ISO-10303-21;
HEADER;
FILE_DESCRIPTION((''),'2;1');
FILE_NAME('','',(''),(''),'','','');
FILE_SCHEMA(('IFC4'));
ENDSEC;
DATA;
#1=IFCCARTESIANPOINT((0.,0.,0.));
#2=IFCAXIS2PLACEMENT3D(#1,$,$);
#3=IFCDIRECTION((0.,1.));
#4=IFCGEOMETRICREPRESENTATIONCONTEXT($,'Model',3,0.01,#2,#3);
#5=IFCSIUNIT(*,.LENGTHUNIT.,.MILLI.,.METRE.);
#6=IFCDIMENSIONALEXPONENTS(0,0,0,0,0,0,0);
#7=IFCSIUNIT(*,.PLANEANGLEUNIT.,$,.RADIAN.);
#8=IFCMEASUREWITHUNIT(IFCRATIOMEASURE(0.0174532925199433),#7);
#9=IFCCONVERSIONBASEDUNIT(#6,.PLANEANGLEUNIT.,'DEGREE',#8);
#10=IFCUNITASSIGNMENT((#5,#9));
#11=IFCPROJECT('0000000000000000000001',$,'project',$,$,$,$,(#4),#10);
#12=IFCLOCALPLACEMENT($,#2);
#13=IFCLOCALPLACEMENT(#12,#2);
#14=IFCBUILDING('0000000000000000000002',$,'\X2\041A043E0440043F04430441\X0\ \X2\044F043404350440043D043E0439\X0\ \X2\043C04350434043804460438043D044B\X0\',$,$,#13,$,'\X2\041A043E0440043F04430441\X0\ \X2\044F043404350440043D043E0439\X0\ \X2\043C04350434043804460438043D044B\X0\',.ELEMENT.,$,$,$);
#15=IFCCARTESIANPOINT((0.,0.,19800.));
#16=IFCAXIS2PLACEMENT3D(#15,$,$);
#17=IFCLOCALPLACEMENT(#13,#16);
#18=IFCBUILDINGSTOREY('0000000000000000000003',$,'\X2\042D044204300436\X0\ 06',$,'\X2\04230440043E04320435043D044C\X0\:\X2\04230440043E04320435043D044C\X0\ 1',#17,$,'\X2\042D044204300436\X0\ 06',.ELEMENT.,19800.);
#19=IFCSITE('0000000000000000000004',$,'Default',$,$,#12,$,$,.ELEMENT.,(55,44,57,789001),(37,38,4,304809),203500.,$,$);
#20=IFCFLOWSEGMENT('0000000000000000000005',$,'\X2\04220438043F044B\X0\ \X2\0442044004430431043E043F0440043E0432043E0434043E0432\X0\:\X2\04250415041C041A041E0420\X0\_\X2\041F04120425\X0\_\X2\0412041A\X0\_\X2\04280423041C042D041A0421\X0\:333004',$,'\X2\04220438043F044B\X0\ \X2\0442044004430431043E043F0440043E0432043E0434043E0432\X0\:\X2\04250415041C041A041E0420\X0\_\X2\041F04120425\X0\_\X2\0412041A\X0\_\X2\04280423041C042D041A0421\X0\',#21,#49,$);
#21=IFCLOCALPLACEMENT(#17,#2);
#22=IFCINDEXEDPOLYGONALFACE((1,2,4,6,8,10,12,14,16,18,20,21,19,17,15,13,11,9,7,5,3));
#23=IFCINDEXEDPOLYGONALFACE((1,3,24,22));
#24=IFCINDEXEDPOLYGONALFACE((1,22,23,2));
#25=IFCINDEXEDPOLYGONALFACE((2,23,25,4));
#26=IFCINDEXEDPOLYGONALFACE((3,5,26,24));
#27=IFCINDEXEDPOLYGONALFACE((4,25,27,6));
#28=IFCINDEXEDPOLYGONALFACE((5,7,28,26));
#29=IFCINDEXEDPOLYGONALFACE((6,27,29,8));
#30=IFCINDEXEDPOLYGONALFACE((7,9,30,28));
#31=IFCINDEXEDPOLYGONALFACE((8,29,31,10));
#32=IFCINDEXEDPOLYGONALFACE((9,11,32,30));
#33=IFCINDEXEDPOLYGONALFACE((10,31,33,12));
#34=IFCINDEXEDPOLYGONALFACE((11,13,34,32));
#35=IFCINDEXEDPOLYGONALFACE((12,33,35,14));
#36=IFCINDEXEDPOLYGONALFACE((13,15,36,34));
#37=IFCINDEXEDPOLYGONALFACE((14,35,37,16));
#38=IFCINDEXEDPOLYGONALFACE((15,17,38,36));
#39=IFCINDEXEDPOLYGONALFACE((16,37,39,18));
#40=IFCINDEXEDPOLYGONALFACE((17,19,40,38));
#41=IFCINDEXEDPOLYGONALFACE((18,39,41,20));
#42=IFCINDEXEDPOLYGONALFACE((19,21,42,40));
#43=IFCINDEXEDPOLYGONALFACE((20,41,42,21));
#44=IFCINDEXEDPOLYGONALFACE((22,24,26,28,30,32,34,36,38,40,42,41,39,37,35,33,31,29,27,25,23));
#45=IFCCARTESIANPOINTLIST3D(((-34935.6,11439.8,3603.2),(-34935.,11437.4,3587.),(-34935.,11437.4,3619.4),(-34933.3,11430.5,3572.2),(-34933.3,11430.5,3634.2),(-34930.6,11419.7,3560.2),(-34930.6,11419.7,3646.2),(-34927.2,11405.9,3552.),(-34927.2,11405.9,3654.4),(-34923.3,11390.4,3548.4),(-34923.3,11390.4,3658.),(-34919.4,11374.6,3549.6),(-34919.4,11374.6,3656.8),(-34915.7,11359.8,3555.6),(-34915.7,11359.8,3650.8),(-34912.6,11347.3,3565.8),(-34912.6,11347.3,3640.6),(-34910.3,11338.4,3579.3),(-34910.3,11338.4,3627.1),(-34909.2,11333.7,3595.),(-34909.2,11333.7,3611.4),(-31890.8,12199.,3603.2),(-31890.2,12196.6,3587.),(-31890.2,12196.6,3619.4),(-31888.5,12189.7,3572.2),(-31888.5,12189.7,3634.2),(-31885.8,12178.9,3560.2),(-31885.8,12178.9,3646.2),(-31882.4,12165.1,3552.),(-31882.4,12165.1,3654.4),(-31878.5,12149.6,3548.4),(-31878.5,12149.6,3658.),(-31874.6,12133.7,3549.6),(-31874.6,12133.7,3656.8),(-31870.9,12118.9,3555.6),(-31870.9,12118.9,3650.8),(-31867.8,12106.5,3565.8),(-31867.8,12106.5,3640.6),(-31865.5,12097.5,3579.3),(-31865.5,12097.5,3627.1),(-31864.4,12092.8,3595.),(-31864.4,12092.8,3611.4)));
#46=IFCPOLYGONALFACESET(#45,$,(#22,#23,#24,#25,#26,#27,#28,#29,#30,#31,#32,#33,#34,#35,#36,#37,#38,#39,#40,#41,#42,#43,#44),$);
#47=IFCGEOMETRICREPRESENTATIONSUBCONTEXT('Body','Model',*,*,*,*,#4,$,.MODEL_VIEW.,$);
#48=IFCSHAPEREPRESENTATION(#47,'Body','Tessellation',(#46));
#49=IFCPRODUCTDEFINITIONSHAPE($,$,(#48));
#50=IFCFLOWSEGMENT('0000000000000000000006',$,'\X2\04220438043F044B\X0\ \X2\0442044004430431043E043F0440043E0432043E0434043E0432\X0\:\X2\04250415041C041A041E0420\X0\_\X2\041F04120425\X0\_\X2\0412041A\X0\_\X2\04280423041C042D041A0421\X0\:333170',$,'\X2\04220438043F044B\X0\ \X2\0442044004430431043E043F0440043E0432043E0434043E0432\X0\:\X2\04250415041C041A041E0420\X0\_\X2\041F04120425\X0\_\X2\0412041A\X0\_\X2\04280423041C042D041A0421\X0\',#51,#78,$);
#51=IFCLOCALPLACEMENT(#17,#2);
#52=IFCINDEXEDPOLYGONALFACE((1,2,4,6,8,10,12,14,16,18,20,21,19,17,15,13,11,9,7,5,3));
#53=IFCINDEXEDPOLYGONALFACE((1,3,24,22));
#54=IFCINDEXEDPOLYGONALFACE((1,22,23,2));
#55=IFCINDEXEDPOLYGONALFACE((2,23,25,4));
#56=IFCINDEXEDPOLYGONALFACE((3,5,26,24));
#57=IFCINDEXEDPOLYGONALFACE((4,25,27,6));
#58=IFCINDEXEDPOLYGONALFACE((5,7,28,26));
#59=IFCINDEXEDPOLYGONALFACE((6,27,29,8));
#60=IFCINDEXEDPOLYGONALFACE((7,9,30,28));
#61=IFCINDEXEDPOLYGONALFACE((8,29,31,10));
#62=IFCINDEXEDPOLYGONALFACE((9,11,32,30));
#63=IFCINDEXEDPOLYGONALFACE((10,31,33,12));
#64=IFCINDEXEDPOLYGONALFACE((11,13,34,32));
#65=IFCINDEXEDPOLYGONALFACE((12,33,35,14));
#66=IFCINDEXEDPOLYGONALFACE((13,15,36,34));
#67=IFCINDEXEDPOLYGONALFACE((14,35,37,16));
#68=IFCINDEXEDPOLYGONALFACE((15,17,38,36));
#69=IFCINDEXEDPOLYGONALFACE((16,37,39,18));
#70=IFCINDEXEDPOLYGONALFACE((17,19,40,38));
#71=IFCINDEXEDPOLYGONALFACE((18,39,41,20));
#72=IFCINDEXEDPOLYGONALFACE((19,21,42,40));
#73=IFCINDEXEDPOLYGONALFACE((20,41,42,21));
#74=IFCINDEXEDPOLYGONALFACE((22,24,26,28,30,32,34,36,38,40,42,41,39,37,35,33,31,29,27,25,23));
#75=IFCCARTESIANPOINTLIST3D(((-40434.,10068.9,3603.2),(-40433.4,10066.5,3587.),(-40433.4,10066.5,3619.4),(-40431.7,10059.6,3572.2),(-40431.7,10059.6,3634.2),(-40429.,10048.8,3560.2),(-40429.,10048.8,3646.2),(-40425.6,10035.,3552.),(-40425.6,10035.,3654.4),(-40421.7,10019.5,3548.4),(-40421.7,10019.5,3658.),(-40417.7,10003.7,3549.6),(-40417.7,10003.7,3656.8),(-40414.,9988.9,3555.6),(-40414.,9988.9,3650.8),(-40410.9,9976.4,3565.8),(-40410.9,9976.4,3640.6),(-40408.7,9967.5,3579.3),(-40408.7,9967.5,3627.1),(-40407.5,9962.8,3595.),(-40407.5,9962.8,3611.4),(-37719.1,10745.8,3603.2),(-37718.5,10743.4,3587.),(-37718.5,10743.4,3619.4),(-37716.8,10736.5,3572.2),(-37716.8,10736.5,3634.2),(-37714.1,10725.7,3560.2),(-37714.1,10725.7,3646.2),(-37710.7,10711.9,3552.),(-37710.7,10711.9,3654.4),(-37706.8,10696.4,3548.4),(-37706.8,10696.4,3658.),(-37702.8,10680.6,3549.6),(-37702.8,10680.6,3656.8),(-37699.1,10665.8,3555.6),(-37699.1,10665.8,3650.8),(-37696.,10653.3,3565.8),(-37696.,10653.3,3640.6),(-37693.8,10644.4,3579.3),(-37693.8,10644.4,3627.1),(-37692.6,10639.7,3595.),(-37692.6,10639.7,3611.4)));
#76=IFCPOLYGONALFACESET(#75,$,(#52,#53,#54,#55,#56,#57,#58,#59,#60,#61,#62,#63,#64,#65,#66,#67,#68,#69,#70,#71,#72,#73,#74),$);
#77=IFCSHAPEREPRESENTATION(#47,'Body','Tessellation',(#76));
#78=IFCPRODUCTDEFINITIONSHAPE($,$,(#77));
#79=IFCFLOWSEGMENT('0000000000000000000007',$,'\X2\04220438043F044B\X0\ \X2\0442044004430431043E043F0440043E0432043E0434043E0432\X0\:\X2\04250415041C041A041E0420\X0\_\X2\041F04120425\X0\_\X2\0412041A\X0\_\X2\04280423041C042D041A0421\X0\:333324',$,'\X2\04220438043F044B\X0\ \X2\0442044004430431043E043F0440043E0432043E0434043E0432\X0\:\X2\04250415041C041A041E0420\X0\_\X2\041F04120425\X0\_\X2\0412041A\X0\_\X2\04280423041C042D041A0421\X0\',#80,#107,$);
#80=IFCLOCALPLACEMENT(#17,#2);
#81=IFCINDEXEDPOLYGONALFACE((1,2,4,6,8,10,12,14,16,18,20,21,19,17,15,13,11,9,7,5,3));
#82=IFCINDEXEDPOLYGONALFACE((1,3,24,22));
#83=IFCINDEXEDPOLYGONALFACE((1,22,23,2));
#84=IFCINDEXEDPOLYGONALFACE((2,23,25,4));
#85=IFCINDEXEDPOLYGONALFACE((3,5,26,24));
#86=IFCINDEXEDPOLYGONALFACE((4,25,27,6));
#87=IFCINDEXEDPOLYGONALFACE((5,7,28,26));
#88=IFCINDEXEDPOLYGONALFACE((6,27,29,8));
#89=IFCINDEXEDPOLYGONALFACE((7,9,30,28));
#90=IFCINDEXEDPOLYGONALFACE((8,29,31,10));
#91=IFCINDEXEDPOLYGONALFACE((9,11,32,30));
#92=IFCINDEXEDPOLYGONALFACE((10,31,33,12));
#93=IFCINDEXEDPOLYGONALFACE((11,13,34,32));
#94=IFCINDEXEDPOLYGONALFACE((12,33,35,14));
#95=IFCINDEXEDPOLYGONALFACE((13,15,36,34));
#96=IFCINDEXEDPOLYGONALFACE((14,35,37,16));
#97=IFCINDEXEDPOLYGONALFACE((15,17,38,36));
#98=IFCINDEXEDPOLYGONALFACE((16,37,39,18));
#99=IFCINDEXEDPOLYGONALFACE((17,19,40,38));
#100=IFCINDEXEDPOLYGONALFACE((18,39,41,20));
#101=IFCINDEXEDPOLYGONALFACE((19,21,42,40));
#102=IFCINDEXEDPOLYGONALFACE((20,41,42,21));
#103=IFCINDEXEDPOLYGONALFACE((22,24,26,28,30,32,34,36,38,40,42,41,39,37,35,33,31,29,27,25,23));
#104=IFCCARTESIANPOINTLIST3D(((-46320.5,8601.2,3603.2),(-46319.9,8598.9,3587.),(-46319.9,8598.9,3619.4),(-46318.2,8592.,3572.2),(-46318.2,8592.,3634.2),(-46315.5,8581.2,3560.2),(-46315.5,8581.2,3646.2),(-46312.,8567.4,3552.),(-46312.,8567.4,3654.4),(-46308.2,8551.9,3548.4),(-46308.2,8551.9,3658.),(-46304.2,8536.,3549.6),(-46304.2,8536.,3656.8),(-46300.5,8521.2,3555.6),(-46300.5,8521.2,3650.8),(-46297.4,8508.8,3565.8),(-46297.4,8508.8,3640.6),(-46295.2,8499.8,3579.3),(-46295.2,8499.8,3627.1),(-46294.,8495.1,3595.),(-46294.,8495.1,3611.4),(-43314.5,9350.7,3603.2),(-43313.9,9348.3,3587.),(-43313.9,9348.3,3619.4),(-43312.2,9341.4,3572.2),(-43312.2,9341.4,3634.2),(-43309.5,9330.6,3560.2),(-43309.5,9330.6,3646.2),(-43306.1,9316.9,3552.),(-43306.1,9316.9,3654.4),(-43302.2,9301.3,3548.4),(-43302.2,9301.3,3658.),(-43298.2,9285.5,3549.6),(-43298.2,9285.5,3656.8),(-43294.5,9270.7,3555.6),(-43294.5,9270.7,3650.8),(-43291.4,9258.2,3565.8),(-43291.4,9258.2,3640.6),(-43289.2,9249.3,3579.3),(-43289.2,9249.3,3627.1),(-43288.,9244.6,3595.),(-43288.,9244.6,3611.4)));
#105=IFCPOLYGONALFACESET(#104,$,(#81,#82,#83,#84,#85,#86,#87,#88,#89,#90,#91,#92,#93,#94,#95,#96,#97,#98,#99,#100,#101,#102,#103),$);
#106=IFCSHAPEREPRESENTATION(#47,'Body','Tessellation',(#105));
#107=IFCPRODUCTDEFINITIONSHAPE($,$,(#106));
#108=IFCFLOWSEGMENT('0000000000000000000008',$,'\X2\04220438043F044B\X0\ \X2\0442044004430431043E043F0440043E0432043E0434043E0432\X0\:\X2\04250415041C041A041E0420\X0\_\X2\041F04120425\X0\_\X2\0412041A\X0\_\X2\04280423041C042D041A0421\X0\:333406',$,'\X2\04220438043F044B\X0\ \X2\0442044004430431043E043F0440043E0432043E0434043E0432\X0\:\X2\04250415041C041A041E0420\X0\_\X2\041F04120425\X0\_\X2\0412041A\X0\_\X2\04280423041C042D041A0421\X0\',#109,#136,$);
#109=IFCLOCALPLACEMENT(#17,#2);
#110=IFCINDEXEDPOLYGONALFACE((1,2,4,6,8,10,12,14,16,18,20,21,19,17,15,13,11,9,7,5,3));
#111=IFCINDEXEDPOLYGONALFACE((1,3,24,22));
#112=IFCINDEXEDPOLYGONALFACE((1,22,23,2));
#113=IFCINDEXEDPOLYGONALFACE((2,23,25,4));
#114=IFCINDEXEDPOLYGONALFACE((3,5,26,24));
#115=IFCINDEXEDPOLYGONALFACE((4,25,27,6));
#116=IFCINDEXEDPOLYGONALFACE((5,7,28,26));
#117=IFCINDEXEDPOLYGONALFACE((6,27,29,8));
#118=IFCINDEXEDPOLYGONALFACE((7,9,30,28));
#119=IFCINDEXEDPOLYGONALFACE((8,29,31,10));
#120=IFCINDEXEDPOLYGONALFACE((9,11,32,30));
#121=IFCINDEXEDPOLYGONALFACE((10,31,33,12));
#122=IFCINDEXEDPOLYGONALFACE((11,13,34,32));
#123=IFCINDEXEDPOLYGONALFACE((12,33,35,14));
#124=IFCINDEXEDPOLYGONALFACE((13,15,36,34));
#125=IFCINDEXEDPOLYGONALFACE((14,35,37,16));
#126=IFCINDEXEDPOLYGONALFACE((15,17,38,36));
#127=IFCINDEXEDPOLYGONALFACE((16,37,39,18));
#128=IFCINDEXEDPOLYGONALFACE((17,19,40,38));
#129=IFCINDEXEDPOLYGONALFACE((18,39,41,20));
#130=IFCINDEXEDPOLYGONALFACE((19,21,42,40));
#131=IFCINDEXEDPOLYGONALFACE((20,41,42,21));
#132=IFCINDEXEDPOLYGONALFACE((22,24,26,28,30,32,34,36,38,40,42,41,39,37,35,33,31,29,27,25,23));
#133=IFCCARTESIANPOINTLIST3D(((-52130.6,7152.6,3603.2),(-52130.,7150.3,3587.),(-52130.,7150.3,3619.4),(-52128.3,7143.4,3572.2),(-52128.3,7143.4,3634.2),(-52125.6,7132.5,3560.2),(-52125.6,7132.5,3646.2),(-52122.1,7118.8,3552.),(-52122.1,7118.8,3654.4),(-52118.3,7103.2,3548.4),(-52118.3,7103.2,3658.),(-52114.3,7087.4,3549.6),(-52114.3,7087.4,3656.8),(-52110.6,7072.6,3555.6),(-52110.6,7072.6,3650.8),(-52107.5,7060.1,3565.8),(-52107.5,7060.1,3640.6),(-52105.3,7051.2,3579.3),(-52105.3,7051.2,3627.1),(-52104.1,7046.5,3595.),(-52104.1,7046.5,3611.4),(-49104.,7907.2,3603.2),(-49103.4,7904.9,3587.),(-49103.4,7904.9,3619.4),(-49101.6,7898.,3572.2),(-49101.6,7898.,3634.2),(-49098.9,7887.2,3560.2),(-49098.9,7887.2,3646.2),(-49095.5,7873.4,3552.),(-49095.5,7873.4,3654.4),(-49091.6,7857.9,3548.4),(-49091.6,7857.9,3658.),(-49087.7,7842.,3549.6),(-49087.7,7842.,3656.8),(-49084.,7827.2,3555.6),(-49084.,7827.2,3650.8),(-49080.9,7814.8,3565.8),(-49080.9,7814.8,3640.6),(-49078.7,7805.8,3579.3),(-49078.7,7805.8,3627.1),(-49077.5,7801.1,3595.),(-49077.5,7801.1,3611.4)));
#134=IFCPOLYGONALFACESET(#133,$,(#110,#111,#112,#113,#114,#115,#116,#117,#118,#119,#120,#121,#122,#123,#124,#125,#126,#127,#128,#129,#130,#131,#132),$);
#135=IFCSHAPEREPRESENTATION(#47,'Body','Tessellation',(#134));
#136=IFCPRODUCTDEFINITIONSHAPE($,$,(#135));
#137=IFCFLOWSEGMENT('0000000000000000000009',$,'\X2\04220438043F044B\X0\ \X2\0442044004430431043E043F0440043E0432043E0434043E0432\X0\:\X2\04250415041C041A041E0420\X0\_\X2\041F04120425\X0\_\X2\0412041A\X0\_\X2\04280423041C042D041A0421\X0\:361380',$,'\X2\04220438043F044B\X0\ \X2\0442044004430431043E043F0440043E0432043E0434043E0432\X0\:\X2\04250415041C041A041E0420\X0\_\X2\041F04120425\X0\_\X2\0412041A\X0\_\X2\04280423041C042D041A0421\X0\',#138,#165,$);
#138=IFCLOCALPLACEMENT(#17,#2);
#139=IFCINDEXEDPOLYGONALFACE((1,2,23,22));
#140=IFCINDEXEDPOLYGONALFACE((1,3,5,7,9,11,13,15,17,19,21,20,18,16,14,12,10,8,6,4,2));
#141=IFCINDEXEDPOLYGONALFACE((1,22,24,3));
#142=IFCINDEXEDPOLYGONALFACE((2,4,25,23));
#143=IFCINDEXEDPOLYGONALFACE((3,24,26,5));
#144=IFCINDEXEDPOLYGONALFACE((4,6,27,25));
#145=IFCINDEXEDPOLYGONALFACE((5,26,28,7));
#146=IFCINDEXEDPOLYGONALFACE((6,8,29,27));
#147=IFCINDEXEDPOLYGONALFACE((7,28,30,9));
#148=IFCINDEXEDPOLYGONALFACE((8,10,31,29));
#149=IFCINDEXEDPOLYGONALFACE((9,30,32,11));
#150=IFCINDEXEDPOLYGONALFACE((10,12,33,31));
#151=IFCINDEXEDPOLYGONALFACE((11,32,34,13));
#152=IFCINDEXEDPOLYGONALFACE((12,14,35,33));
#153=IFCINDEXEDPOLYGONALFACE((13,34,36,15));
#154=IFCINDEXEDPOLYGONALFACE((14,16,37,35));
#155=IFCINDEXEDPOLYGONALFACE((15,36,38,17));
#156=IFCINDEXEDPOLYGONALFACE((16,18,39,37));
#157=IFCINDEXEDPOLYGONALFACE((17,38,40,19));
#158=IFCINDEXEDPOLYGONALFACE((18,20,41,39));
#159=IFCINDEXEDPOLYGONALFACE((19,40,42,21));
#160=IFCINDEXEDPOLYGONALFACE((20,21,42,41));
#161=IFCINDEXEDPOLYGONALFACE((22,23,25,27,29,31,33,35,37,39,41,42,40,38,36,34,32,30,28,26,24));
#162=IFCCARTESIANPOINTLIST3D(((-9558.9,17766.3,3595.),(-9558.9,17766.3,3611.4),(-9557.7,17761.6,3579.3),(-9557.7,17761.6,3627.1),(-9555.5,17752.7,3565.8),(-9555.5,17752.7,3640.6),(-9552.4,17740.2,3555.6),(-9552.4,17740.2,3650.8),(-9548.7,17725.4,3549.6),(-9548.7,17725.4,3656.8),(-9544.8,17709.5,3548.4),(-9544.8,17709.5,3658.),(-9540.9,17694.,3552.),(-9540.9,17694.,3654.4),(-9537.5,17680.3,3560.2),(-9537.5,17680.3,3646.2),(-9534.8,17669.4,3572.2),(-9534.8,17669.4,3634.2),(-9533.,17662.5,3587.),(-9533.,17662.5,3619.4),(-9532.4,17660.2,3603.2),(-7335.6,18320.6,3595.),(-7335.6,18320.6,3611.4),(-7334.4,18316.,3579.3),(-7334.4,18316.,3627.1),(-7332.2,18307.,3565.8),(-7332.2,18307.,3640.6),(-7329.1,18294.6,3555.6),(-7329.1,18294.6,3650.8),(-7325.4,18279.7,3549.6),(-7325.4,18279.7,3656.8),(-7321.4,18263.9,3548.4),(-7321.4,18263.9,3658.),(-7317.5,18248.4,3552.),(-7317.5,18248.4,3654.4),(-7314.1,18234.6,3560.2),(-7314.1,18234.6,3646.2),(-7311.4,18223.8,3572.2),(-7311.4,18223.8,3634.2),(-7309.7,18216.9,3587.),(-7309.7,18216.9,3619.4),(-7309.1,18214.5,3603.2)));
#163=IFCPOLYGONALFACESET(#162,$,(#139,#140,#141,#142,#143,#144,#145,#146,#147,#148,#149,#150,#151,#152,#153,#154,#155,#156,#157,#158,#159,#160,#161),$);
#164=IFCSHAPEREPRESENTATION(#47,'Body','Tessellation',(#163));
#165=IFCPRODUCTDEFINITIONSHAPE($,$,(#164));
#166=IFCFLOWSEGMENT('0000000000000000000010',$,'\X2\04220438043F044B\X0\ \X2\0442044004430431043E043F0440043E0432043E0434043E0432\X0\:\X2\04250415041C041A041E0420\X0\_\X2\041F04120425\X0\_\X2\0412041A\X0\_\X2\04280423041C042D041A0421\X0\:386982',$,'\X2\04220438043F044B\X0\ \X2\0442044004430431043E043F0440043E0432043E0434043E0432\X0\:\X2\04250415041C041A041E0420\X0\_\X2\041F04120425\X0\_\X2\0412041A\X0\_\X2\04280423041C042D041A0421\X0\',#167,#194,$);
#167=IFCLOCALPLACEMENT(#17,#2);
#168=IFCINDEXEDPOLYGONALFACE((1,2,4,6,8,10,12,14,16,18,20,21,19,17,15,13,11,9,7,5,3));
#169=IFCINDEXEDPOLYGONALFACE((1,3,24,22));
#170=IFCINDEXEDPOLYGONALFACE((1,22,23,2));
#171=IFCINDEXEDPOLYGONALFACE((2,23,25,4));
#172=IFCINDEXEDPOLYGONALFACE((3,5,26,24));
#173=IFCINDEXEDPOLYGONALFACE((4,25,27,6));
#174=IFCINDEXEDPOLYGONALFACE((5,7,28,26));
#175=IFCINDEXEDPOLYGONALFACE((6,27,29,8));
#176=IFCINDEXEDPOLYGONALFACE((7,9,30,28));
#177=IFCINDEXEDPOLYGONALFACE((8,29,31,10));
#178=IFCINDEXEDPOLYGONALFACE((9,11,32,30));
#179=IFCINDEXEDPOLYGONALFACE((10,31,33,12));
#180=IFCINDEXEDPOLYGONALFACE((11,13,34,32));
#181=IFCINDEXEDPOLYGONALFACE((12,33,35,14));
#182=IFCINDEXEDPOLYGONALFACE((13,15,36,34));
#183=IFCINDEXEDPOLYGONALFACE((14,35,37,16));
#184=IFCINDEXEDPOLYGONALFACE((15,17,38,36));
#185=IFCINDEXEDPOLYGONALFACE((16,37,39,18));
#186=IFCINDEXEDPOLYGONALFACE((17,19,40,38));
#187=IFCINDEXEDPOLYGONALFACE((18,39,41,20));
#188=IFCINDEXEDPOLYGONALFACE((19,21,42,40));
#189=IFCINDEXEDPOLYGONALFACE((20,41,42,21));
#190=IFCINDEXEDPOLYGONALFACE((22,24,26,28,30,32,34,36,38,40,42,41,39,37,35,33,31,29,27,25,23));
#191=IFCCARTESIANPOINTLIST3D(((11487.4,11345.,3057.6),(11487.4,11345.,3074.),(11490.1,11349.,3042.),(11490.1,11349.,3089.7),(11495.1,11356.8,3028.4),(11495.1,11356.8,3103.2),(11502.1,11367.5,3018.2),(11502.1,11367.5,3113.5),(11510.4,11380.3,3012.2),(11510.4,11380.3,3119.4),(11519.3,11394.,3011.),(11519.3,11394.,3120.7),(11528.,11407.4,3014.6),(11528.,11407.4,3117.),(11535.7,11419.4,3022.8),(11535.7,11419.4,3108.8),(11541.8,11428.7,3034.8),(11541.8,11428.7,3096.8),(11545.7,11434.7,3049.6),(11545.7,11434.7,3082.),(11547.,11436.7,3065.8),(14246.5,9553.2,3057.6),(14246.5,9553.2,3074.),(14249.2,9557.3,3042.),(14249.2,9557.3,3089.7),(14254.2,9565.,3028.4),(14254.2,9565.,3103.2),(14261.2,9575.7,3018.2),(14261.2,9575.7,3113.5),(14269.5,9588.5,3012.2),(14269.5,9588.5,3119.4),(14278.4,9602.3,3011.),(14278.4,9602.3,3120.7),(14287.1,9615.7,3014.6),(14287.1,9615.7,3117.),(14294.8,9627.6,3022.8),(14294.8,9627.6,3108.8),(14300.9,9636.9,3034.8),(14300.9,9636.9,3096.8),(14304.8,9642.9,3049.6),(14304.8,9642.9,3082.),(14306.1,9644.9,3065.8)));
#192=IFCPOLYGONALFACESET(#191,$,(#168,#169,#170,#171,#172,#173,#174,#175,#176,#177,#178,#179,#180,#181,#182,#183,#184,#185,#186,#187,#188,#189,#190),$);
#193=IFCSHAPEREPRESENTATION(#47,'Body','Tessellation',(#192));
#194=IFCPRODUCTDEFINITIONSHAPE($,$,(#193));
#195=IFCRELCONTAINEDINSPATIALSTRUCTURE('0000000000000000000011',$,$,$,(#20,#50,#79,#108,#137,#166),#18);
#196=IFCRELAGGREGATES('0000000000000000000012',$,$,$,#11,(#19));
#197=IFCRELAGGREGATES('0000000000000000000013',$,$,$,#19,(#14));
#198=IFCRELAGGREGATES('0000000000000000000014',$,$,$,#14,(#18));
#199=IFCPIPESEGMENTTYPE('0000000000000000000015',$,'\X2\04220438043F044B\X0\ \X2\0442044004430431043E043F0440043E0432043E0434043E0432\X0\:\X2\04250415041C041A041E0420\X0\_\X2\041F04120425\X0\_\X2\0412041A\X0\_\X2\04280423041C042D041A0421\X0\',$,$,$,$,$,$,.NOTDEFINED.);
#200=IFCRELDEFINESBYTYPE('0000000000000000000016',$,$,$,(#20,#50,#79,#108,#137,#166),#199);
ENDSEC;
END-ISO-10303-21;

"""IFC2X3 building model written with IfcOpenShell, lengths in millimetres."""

from ifc_helpers import new_model, entity, si_unit, converted_unit, direction, frame, origin, origin_2d_with_axis, place, context, subcontext, project, spatial, circle, extrude, type_object, element, save


model = new_model("IFC2X3")

# Units and contexts
model_context = context("Model", 3, precision=0.01, world=origin(), true_north=direction((0.0, 1.0)))
body_context = subcontext(model_context, "Body", "Model", "MODEL_VIEW")
ifc_project = project(units=[si_unit("LENGTHUNIT", "METRE", prefix="MILLI"), converted_unit("PLANEANGLEUNIT", "DEGREE", entity("IfcRatioMeasure", 0.0174532925199433), si_unit("PLANEANGLEUNIT", "RADIAN"), dimensions=[0, 0, 0, 0, 0, 0, 0])], contexts=[model_context])

# Site, building, storey
site_placement = place(None, origin())
site = spatial("IfcSite", under=ifc_project, at=site_placement, Name="Default", CompositionType="ELEMENT", RefLatitude=(55, 44, 57, 789001), RefLongitude=(37, 38, 4, 304809), RefElevation=203500.0)
building_placement = place(site_placement, origin())
building = spatial("IfcBuilding", under=site, at=building_placement, Name="Корпус ядерной медицины", LongName="Корпус ядерной медицины", CompositionType="ELEMENT")
storey_placement = place(building_placement, frame((0.0, 0.0, 19800.0)))
storey = spatial("IfcBuildingStorey", under=building, at=storey_placement, Name="Этаж 06", ObjectType="Уровень:Уровень 1", LongName="Этаж 06", CompositionType="ELEMENT", Elevation=19800.0)

# Flow segments
pipe_segment_type = type_object("IfcPipeSegmentType", Name="Типы трубопроводов:ХЕМКОР_ПВХ_ВК_ШУМЭКС", PredefinedType="NOTDEFINED")
flow_segment_1_placement = place(storey_placement, frame((-34937.2, 11331.5, 3546.6)))
element("IfcFlowSegment", 1, at=flow_segment_1_placement, inside=storey, type_object=pipe_segment_type, Name="Типы трубопроводов:ХЕМКОР_ПВХ_ВК_ШУМЭКС:333004", ObjectType="Типы трубопроводов:ХЕМКОР_ПВХ_ВК_ШУМЭКС", context=body_context, shape_type="SweptSolid", body=[
    extrude(circle(Radius=55.0, at=origin_2d_with_axis()), frame((14.9, 55.0, 56.6), z_axis=(0.970296, 0.241922, 0.0), x_axis=(-0.241922, 0.970296, 0.0)), (0.0, 0.0, 1.0), 3138.0),
])
flow_segment_2_placement = place(storey_placement, frame((-40435.6, 9960.6, 3546.6)))
element("IfcFlowSegment", 2, at=flow_segment_2_placement, inside=storey, type_object=pipe_segment_type, Name="Типы трубопроводов:ХЕМКОР_ПВХ_ВК_ШУМЭКС:333170", ObjectType="Типы трубопроводов:ХЕМКОР_ПВХ_ВК_ШУМЭКС", context=body_context, shape_type="SweptSolid", body=[
    extrude(circle(Radius=55.0, at=origin_2d_with_axis()), frame((14.9, 55.0, 56.6), z_axis=(0.970296, 0.241922, 0.0), x_axis=(-0.241922, 0.970296, 0.0)), (0.0, 0.0, 1.0), 2798.0),
])
flow_segment_3_placement = place(storey_placement, frame((-46322.1, 8492.9, 3546.6)))
element("IfcFlowSegment", 3, at=flow_segment_3_placement, inside=storey, type_object=pipe_segment_type, Name="Типы трубопроводов:ХЕМКОР_ПВХ_ВК_ШУМЭКС:333324", ObjectType="Типы трубопроводов:ХЕМКОР_ПВХ_ВК_ШУМЭКС", context=body_context, shape_type="SweptSolid", body=[
    extrude(circle(Radius=55.0, at=origin_2d_with_axis()), frame((14.9, 55.0, 56.6), z_axis=(0.970296, 0.241922, 0.0), x_axis=(-0.241922, 0.970296, 0.0)), (0.0, 0.0, 1.0), 3098.0),
])
flow_segment_4_placement = place(storey_placement, frame((-52132.2, 7044.3, 3546.6)))
element("IfcFlowSegment", 4, at=flow_segment_4_placement, inside=storey, type_object=pipe_segment_type, Name="Типы трубопроводов:ХЕМКОР_ПВХ_ВК_ШУМЭКС:333406", ObjectType="Типы трубопроводов:ХЕМКОР_ПВХ_ВК_ШУМЭКС", context=body_context, shape_type="SweptSolid", body=[
    extrude(circle(Radius=55.0, at=origin_2d_with_axis()), frame((14.9, 55.0, 56.6), z_axis=(0.970296, 0.241922, 0.0), x_axis=(-0.241922, 0.970296, 0.0)), (0.0, 0.0, 1.0), 3119.3),
])
flow_segment_5_placement = place(storey_placement, frame((-9560.6, 17658.6, 3546.6)))
element("IfcFlowSegment", 5, at=flow_segment_5_placement, inside=storey, type_object=pipe_segment_type, Name="Типы трубопроводов:ХЕМКОР_ПВХ_ВК_ШУМЭКС:361380", ObjectType="Типы трубопроводов:ХЕМКОР_ПВХ_ВК_ШУМЭКС", context=body_context, shape_type="SweptSolid", body=[
    extrude(circle(Radius=55.0, at=origin_2d_with_axis()), frame((14.9, 55.0, 56.6), z_axis=(0.970296, 0.241922, 0.0), x_axis=(0.241922, -0.970296, 0.0)), (0.0, 0.0, 1.0), 2291.4),
])
flow_segment_6_placement = place(storey_placement, frame((11485.5, 9551.1, 3009.2)))
element("IfcFlowSegment", 6, at=flow_segment_6_placement, inside=storey, type_object=pipe_segment_type, Name="Типы трубопроводов:ХЕМКОР_ПВХ_ВК_ШУМЭКС:386982", ObjectType="Типы трубопроводов:ХЕМКОР_ПВХ_ВК_ШУМЭКС", context=body_context, shape_type="SweptSolid", body=[
    extrude(circle(Radius=55.0, at=origin_2d_with_axis()), frame((2790.7, 47.7, 56.6), z_axis=(-0.838671, 0.544639, 0.0), x_axis=(0.544639, 0.838671, 0.0)), (0.0, 0.0, 1.0), 3289.9),
])

save(model, "model.ifc")
